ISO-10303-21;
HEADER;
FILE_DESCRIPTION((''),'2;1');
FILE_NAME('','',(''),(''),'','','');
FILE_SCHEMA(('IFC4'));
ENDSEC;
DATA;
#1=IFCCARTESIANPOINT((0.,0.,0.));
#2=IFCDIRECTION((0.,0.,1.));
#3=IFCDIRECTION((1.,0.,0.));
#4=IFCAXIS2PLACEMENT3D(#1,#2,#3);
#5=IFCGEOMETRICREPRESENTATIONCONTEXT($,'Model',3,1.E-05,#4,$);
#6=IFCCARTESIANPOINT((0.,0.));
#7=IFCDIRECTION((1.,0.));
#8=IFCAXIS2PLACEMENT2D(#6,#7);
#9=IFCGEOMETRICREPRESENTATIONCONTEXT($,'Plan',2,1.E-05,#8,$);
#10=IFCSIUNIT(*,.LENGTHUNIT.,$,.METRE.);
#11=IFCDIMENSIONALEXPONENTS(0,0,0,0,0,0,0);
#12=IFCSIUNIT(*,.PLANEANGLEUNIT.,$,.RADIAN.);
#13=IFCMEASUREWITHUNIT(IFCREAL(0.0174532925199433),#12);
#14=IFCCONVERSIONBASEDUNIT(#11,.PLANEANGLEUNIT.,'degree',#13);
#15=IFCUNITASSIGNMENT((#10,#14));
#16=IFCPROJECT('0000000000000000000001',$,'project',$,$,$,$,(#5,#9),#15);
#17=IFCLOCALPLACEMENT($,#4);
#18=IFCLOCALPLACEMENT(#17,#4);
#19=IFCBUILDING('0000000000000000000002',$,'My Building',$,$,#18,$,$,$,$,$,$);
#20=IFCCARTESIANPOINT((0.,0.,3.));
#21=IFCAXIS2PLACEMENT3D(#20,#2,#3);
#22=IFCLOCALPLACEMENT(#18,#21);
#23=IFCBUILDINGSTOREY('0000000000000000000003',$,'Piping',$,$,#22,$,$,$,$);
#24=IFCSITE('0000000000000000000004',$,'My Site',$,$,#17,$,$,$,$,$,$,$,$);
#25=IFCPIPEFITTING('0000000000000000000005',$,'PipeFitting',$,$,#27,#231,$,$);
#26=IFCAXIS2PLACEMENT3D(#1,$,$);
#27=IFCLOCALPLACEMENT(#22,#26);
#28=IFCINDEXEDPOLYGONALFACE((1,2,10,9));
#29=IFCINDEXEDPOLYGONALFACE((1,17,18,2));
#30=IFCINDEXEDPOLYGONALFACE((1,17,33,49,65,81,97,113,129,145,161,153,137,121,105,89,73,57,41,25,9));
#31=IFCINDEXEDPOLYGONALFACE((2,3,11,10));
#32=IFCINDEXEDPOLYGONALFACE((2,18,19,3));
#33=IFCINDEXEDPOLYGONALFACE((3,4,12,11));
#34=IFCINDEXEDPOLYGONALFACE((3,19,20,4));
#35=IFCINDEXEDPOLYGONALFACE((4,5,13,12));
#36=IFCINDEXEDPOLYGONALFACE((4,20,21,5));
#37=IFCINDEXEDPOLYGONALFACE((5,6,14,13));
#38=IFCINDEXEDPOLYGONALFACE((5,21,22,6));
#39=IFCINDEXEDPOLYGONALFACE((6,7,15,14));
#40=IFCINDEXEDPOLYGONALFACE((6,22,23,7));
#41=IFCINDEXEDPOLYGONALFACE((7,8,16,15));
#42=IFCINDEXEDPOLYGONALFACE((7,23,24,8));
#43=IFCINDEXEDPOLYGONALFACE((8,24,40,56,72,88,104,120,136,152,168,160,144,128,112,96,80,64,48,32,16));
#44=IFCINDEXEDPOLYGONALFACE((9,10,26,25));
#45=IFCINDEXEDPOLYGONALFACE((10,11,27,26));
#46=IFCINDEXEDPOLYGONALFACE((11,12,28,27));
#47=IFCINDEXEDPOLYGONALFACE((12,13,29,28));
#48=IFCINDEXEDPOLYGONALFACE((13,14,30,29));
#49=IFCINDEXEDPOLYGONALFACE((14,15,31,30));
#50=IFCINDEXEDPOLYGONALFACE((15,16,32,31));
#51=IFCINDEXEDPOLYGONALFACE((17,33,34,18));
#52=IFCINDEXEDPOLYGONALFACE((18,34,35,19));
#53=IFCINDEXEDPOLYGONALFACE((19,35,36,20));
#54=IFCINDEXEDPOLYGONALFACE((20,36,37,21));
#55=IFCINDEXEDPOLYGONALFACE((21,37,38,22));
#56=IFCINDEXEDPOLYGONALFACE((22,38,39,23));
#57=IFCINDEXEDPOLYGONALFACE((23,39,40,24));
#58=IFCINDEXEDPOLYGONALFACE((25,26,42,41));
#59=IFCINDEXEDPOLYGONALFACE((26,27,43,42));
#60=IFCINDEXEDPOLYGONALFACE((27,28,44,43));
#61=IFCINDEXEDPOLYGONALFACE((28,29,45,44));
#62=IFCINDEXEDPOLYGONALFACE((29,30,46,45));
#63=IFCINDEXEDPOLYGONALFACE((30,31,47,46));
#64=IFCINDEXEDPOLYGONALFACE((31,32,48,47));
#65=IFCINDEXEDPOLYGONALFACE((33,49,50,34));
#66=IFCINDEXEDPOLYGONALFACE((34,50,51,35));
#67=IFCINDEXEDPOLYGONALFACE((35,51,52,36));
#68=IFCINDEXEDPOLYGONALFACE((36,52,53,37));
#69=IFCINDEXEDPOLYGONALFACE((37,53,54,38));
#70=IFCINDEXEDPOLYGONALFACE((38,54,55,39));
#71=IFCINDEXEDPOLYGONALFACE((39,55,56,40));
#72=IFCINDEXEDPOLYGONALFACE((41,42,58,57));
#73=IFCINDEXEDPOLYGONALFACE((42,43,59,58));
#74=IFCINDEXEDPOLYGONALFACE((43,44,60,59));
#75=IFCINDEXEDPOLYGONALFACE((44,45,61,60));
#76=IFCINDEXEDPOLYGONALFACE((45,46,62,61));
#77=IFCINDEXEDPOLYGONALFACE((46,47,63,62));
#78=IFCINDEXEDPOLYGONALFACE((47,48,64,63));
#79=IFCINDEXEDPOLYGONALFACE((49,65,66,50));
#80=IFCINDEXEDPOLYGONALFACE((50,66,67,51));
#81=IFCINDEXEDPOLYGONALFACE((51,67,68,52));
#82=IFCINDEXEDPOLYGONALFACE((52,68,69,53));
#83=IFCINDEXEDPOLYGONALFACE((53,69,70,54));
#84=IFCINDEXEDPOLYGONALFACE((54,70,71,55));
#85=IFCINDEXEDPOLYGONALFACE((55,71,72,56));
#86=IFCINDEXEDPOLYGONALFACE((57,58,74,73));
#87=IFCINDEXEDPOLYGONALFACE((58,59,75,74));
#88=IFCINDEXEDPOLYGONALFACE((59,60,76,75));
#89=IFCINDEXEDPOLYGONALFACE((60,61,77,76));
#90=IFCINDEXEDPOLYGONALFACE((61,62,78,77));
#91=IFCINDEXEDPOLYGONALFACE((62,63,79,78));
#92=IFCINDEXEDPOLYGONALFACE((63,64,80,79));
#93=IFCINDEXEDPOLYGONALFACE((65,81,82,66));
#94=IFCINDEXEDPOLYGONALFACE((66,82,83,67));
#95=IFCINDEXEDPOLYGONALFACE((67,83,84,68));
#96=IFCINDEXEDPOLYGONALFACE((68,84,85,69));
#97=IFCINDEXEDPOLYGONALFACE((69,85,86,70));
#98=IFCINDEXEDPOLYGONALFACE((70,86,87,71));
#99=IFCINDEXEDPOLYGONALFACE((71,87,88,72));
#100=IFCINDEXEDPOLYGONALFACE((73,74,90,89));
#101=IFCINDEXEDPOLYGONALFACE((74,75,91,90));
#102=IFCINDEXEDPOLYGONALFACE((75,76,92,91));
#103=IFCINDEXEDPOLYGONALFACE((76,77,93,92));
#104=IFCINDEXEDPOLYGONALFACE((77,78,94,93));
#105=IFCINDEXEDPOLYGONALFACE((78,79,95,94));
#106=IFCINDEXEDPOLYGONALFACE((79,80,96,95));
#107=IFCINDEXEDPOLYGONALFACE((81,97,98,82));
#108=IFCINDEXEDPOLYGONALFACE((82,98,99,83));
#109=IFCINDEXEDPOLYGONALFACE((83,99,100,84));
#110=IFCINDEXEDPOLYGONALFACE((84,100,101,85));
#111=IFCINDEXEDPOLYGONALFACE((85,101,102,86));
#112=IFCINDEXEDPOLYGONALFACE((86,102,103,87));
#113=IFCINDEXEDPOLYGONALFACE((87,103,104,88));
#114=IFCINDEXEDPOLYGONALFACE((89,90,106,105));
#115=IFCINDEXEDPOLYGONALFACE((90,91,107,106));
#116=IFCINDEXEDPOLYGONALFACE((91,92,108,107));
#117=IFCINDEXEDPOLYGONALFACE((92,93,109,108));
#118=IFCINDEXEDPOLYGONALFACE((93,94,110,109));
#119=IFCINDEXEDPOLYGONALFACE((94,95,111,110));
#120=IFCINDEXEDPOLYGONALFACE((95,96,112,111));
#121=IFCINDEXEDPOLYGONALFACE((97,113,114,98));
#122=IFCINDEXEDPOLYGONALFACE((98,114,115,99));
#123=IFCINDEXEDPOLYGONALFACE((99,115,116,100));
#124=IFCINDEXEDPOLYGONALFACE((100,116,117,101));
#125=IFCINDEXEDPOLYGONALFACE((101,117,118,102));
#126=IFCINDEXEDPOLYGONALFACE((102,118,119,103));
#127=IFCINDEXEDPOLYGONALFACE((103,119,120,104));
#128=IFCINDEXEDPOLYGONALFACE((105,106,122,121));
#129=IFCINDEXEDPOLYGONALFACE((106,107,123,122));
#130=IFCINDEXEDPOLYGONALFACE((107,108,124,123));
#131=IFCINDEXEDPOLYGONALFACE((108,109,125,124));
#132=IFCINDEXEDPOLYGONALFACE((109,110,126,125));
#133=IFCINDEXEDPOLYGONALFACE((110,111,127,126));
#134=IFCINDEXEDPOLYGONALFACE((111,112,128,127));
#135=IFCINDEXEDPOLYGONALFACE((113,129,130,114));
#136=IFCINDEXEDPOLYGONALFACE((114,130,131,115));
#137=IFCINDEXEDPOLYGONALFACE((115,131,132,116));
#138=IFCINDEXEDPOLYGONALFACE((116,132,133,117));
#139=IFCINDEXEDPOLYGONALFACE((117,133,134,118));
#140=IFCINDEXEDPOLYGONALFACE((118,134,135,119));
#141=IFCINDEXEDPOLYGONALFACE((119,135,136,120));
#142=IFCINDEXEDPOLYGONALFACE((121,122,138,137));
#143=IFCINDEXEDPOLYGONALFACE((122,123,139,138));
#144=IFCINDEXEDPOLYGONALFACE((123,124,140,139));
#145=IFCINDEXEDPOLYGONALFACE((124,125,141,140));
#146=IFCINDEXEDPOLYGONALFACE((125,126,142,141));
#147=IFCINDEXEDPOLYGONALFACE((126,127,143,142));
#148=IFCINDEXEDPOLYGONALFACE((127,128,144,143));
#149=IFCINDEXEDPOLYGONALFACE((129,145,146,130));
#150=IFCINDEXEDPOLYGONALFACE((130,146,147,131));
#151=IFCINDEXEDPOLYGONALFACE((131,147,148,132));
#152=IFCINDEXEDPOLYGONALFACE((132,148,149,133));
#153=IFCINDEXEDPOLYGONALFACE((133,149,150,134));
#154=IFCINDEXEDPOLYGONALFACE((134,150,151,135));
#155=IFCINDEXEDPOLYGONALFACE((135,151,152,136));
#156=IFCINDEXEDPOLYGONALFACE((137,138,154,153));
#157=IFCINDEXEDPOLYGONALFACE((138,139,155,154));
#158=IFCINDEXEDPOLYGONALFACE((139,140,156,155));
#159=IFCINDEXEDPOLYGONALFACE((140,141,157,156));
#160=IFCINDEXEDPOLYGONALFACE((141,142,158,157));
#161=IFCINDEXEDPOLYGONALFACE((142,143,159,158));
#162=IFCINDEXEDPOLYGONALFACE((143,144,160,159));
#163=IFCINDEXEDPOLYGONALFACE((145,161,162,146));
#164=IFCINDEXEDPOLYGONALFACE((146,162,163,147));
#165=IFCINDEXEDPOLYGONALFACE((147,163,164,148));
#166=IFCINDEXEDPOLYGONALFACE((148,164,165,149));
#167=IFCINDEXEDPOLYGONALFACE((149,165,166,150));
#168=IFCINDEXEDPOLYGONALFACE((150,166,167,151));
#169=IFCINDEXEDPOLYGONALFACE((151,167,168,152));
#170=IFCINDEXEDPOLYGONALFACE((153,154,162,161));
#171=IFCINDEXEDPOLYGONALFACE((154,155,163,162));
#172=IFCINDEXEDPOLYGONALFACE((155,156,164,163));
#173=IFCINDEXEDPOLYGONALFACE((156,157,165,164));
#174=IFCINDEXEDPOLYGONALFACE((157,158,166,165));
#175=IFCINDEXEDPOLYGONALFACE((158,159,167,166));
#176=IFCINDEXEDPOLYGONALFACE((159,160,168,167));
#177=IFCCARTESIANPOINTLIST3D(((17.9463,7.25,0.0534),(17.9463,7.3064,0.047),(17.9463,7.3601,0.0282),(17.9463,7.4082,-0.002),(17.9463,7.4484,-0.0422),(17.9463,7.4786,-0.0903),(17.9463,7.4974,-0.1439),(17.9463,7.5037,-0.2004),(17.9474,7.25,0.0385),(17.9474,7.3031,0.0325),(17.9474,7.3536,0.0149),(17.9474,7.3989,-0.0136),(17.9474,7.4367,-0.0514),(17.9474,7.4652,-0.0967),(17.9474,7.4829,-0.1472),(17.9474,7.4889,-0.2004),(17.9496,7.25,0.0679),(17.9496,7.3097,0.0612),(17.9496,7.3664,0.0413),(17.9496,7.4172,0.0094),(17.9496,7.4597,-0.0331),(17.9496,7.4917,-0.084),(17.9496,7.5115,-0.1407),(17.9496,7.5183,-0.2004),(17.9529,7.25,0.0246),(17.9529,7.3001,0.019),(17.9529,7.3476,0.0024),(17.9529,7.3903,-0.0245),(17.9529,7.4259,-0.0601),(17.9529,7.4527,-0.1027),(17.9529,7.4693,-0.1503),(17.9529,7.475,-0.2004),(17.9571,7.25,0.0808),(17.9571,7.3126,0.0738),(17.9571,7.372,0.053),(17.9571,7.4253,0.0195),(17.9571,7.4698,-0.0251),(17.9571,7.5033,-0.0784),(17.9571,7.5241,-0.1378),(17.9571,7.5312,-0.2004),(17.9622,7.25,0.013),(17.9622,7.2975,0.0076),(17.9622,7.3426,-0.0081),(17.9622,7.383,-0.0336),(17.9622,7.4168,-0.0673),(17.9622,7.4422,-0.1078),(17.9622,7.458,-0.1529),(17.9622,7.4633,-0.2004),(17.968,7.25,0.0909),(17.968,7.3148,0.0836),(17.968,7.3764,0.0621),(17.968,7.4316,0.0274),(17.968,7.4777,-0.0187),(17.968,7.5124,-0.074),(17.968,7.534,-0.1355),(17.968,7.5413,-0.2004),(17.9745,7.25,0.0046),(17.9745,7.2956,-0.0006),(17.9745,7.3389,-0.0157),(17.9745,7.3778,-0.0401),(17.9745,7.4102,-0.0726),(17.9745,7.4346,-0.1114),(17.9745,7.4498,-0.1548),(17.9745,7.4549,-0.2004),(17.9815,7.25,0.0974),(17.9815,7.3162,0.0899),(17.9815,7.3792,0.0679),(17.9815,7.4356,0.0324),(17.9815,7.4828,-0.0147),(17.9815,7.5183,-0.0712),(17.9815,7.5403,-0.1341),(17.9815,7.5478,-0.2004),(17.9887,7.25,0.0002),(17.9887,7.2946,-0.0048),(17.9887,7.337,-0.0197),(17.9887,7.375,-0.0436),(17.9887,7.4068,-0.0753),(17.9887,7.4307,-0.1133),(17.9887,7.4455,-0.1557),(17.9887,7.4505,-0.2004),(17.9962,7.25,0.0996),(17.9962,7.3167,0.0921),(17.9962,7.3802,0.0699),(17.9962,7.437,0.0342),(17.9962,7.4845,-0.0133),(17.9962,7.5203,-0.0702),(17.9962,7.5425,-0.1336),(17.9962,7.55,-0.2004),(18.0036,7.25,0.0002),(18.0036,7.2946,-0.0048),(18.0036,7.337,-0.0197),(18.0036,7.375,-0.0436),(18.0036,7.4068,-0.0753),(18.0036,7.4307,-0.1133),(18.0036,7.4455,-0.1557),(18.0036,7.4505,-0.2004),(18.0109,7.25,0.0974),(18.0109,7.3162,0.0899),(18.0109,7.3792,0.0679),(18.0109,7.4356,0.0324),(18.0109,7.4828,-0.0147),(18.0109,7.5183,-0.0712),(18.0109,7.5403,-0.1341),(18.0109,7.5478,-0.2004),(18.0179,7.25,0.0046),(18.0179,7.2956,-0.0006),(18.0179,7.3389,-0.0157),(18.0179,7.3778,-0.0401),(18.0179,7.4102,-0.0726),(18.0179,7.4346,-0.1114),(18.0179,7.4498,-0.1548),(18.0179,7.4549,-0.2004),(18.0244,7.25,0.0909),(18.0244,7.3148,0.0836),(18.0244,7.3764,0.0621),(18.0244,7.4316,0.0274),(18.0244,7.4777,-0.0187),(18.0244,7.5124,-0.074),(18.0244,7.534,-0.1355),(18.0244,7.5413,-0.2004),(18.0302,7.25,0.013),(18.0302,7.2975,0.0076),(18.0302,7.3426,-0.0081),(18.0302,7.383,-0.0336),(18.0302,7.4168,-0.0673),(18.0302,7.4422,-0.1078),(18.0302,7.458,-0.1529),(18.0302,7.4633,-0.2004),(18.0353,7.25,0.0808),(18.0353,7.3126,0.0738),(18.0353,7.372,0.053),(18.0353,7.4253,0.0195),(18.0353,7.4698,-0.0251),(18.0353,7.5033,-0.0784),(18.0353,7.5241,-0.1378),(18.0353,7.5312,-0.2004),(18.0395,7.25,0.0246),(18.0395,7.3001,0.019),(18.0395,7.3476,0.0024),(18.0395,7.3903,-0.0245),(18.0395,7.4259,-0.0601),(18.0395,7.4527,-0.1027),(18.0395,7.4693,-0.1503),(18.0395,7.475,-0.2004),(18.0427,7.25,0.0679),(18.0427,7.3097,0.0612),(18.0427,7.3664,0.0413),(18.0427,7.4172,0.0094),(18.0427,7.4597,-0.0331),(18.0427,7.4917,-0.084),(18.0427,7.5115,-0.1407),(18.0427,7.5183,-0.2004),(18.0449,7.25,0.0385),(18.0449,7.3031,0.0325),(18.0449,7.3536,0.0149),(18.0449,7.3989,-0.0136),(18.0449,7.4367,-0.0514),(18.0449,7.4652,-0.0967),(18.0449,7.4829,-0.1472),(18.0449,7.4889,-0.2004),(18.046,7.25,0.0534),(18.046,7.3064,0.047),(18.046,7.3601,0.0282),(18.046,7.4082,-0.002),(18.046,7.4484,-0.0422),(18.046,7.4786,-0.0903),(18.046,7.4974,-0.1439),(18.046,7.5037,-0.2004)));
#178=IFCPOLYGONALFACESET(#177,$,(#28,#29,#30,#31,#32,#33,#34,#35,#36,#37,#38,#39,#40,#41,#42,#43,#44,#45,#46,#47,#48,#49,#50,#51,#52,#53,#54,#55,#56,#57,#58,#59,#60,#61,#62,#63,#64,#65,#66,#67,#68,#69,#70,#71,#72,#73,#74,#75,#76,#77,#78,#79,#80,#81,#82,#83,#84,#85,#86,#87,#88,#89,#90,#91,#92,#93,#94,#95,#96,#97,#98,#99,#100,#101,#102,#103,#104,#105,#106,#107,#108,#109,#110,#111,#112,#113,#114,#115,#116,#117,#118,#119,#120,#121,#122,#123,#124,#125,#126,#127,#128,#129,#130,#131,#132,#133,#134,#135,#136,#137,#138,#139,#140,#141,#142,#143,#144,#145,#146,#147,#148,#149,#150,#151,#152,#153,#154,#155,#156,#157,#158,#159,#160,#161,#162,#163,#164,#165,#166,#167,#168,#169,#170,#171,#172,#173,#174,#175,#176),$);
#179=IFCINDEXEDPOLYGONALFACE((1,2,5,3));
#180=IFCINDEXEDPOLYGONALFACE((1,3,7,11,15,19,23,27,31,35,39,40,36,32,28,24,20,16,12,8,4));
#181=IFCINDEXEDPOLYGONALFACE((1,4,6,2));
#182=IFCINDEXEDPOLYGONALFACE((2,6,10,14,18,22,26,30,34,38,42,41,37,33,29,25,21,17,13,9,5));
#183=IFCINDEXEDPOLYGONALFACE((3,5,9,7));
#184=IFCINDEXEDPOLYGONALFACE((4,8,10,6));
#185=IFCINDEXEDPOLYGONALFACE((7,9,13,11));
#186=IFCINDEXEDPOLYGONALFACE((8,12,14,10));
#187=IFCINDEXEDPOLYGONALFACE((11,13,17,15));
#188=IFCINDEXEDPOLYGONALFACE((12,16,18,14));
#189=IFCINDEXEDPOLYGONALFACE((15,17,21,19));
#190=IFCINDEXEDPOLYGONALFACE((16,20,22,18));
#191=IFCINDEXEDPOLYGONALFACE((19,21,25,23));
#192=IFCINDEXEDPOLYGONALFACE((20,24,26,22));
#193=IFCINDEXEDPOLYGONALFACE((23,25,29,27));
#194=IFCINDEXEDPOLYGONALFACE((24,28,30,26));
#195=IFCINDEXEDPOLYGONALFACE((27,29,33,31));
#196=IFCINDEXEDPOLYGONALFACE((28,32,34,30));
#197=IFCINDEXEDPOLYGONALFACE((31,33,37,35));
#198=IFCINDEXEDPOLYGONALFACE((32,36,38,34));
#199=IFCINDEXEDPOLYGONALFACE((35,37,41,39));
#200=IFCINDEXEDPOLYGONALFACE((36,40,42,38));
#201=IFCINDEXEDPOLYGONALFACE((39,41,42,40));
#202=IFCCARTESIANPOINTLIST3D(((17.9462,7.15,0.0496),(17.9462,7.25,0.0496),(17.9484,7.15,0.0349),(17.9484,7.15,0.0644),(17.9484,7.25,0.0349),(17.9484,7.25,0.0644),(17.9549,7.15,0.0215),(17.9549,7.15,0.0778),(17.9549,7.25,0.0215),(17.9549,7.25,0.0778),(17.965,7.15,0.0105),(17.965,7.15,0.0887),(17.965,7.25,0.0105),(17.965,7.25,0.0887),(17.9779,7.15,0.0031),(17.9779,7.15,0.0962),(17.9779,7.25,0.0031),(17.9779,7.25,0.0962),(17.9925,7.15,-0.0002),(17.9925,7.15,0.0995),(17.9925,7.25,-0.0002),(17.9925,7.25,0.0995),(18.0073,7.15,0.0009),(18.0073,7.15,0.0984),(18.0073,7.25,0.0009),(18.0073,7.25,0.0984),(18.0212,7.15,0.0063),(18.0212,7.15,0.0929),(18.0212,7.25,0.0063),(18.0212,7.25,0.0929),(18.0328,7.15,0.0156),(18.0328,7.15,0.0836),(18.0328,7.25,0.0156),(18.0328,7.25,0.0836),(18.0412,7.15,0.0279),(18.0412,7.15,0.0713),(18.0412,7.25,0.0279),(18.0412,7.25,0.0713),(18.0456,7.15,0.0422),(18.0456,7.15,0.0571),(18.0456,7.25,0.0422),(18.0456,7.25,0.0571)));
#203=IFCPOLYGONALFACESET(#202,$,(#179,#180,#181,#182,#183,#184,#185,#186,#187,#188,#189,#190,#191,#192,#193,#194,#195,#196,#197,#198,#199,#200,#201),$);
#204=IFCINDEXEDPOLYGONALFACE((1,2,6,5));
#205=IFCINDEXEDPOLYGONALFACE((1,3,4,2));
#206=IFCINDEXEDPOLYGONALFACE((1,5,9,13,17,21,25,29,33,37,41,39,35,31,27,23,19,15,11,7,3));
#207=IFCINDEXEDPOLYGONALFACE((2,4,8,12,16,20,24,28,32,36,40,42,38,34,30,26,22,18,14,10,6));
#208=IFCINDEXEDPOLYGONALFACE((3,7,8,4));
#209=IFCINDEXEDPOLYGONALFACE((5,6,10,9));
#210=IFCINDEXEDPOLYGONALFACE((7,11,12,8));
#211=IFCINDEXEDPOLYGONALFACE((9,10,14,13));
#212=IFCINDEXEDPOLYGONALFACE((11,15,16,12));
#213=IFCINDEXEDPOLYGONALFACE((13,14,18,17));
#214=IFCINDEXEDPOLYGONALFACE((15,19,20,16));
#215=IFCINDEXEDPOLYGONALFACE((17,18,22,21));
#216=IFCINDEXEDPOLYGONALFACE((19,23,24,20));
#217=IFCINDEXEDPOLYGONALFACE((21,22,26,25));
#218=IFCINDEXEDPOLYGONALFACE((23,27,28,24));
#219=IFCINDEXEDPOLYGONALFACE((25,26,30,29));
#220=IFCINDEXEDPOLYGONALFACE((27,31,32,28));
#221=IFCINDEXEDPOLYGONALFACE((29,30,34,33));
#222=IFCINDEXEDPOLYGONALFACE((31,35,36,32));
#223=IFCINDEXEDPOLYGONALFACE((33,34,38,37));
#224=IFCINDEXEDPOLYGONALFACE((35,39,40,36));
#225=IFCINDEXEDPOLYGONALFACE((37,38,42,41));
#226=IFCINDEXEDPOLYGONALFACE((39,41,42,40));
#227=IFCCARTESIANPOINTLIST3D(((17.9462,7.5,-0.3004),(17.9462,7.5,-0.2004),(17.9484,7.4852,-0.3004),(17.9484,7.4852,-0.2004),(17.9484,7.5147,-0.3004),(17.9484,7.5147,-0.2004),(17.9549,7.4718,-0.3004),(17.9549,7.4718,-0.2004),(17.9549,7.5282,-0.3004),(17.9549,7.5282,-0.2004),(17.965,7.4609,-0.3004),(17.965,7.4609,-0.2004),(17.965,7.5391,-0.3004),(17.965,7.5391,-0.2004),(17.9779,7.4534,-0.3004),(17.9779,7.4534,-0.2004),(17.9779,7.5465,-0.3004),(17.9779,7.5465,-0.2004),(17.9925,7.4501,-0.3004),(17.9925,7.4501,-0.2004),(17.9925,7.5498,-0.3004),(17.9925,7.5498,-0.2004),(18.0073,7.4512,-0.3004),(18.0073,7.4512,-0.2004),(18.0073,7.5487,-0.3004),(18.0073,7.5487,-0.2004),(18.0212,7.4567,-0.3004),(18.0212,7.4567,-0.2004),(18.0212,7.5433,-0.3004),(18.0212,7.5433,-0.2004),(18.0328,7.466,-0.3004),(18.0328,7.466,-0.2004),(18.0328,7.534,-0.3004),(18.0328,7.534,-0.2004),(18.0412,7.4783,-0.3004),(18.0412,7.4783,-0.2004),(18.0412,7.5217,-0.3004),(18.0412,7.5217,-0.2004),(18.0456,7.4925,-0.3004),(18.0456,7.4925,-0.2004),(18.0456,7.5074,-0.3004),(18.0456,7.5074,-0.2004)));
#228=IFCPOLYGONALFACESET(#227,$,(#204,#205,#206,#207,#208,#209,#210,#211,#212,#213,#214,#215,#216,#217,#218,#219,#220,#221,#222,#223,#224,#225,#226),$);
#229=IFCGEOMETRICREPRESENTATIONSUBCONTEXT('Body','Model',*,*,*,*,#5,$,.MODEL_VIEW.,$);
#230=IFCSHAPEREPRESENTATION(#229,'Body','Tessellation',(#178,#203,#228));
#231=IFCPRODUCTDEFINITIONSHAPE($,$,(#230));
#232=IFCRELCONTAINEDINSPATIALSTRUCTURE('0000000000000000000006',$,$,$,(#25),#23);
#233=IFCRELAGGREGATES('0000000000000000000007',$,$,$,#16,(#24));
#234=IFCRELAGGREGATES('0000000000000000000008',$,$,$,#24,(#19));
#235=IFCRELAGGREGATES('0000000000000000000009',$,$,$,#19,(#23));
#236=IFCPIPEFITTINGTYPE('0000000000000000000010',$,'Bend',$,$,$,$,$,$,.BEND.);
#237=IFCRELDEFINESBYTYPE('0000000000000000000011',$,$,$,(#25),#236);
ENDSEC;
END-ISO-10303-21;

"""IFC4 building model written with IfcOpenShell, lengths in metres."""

from ifc_helpers import new_model, entity, si_unit, converted_unit, frame, origin_with_axes, origin_2d_with_axis, place, context, subcontext, project, spatial, circle, extrude, source, transform, mapped, type_object, type_shapes, element, save


model = new_model("IFC4")

# Units and contexts
model_context = context("Model", 3, precision=1e-05, world=origin_with_axes())
plan_context = context("Plan", 2, precision=1e-05, world=origin_2d_with_axis())
body_context = subcontext(model_context, "Body", "Model", "MODEL_VIEW")
ifc_project = project(units=[si_unit("LENGTHUNIT", "METRE"), converted_unit("PLANEANGLEUNIT", "degree", entity("IfcReal", 0.0174532925199433), si_unit("PLANEANGLEUNIT", "RADIAN"), dimensions=[0, 0, 0, 0, 0, 0, 0])], contexts=[model_context, plan_context])

# Site, building, storey
site_placement = place(None, origin_with_axes())
site = spatial("IfcSite", under=ifc_project, at=site_placement, Name="My Site")
building_placement = place(site_placement, origin_with_axes())
building = spatial("IfcBuilding", under=site, at=building_placement, Name="My Building")
storey_placement = place(building_placement, frame((0.0, 0.0, 3.0), z_axis=(0.0, 0.0, 1.0), x_axis=(1.0, 0.0, 0.0)))
storey = spatial("IfcBuildingStorey", under=building, at=storey_placement, Name="Piping")

# Pipe fitting
pipe_fitting_type_1 = type_object("IfcPipeFittingType", Name="Bend", PredefinedType="BEND")
shared_shape = source(origin_with_axes(), body_context, "Body", "SolidModel", [
    entity("IfcSweptDiskSolid", entity("IfcIndexedPolyCurve", entity("IfcCartesianPointList3D", [[0.0, 0.0, 0.1], [0.0, -0.0732, 0.2768], [0.0, -0.25, 0.35]]), [entity("IfcArcIndex", [1, 2, 3])]), 0.05),
    extrude(circle(Radius=0.05), origin_with_axes(), (0.0, 0.0, 1.0), 0.1),
    extrude(circle(Radius=0.05), frame((0.0, -0.25, 0.35), z_axis=(0.0, -1.0, 0.0), x_axis=(1.0, 0.0, 0.0)), (0.0, 0.0, 1.0), 0.1),
])
type_shapes(pipe_fitting_type_1, [shared_shape])
for number, where, z_axis, x_axis, name in (
    (1, (17.9962, 7.15, 0.0496), (0.0, 1.0, 0.0), (-1.0, 0.0, 0.0), "PipeFitting"),
):
    element("IfcPipeFitting", number, at=place(storey_placement, frame(where, z_axis=z_axis, x_axis=x_axis)), inside=storey, type_object=pipe_fitting_type_1, Name=name, context=body_context, shape_type="MappedRepresentation", body=[
        mapped(shared_shape, transform((0.0, 0.0, 0.0), x_axis=(1.0, 0.0, 0.0), y_axis=(0.0, 1.0, 0.0), z_axis=(0.0, 0.0, 1.0), scale=1.0)),
    ])

save(model, "model.ifc")
